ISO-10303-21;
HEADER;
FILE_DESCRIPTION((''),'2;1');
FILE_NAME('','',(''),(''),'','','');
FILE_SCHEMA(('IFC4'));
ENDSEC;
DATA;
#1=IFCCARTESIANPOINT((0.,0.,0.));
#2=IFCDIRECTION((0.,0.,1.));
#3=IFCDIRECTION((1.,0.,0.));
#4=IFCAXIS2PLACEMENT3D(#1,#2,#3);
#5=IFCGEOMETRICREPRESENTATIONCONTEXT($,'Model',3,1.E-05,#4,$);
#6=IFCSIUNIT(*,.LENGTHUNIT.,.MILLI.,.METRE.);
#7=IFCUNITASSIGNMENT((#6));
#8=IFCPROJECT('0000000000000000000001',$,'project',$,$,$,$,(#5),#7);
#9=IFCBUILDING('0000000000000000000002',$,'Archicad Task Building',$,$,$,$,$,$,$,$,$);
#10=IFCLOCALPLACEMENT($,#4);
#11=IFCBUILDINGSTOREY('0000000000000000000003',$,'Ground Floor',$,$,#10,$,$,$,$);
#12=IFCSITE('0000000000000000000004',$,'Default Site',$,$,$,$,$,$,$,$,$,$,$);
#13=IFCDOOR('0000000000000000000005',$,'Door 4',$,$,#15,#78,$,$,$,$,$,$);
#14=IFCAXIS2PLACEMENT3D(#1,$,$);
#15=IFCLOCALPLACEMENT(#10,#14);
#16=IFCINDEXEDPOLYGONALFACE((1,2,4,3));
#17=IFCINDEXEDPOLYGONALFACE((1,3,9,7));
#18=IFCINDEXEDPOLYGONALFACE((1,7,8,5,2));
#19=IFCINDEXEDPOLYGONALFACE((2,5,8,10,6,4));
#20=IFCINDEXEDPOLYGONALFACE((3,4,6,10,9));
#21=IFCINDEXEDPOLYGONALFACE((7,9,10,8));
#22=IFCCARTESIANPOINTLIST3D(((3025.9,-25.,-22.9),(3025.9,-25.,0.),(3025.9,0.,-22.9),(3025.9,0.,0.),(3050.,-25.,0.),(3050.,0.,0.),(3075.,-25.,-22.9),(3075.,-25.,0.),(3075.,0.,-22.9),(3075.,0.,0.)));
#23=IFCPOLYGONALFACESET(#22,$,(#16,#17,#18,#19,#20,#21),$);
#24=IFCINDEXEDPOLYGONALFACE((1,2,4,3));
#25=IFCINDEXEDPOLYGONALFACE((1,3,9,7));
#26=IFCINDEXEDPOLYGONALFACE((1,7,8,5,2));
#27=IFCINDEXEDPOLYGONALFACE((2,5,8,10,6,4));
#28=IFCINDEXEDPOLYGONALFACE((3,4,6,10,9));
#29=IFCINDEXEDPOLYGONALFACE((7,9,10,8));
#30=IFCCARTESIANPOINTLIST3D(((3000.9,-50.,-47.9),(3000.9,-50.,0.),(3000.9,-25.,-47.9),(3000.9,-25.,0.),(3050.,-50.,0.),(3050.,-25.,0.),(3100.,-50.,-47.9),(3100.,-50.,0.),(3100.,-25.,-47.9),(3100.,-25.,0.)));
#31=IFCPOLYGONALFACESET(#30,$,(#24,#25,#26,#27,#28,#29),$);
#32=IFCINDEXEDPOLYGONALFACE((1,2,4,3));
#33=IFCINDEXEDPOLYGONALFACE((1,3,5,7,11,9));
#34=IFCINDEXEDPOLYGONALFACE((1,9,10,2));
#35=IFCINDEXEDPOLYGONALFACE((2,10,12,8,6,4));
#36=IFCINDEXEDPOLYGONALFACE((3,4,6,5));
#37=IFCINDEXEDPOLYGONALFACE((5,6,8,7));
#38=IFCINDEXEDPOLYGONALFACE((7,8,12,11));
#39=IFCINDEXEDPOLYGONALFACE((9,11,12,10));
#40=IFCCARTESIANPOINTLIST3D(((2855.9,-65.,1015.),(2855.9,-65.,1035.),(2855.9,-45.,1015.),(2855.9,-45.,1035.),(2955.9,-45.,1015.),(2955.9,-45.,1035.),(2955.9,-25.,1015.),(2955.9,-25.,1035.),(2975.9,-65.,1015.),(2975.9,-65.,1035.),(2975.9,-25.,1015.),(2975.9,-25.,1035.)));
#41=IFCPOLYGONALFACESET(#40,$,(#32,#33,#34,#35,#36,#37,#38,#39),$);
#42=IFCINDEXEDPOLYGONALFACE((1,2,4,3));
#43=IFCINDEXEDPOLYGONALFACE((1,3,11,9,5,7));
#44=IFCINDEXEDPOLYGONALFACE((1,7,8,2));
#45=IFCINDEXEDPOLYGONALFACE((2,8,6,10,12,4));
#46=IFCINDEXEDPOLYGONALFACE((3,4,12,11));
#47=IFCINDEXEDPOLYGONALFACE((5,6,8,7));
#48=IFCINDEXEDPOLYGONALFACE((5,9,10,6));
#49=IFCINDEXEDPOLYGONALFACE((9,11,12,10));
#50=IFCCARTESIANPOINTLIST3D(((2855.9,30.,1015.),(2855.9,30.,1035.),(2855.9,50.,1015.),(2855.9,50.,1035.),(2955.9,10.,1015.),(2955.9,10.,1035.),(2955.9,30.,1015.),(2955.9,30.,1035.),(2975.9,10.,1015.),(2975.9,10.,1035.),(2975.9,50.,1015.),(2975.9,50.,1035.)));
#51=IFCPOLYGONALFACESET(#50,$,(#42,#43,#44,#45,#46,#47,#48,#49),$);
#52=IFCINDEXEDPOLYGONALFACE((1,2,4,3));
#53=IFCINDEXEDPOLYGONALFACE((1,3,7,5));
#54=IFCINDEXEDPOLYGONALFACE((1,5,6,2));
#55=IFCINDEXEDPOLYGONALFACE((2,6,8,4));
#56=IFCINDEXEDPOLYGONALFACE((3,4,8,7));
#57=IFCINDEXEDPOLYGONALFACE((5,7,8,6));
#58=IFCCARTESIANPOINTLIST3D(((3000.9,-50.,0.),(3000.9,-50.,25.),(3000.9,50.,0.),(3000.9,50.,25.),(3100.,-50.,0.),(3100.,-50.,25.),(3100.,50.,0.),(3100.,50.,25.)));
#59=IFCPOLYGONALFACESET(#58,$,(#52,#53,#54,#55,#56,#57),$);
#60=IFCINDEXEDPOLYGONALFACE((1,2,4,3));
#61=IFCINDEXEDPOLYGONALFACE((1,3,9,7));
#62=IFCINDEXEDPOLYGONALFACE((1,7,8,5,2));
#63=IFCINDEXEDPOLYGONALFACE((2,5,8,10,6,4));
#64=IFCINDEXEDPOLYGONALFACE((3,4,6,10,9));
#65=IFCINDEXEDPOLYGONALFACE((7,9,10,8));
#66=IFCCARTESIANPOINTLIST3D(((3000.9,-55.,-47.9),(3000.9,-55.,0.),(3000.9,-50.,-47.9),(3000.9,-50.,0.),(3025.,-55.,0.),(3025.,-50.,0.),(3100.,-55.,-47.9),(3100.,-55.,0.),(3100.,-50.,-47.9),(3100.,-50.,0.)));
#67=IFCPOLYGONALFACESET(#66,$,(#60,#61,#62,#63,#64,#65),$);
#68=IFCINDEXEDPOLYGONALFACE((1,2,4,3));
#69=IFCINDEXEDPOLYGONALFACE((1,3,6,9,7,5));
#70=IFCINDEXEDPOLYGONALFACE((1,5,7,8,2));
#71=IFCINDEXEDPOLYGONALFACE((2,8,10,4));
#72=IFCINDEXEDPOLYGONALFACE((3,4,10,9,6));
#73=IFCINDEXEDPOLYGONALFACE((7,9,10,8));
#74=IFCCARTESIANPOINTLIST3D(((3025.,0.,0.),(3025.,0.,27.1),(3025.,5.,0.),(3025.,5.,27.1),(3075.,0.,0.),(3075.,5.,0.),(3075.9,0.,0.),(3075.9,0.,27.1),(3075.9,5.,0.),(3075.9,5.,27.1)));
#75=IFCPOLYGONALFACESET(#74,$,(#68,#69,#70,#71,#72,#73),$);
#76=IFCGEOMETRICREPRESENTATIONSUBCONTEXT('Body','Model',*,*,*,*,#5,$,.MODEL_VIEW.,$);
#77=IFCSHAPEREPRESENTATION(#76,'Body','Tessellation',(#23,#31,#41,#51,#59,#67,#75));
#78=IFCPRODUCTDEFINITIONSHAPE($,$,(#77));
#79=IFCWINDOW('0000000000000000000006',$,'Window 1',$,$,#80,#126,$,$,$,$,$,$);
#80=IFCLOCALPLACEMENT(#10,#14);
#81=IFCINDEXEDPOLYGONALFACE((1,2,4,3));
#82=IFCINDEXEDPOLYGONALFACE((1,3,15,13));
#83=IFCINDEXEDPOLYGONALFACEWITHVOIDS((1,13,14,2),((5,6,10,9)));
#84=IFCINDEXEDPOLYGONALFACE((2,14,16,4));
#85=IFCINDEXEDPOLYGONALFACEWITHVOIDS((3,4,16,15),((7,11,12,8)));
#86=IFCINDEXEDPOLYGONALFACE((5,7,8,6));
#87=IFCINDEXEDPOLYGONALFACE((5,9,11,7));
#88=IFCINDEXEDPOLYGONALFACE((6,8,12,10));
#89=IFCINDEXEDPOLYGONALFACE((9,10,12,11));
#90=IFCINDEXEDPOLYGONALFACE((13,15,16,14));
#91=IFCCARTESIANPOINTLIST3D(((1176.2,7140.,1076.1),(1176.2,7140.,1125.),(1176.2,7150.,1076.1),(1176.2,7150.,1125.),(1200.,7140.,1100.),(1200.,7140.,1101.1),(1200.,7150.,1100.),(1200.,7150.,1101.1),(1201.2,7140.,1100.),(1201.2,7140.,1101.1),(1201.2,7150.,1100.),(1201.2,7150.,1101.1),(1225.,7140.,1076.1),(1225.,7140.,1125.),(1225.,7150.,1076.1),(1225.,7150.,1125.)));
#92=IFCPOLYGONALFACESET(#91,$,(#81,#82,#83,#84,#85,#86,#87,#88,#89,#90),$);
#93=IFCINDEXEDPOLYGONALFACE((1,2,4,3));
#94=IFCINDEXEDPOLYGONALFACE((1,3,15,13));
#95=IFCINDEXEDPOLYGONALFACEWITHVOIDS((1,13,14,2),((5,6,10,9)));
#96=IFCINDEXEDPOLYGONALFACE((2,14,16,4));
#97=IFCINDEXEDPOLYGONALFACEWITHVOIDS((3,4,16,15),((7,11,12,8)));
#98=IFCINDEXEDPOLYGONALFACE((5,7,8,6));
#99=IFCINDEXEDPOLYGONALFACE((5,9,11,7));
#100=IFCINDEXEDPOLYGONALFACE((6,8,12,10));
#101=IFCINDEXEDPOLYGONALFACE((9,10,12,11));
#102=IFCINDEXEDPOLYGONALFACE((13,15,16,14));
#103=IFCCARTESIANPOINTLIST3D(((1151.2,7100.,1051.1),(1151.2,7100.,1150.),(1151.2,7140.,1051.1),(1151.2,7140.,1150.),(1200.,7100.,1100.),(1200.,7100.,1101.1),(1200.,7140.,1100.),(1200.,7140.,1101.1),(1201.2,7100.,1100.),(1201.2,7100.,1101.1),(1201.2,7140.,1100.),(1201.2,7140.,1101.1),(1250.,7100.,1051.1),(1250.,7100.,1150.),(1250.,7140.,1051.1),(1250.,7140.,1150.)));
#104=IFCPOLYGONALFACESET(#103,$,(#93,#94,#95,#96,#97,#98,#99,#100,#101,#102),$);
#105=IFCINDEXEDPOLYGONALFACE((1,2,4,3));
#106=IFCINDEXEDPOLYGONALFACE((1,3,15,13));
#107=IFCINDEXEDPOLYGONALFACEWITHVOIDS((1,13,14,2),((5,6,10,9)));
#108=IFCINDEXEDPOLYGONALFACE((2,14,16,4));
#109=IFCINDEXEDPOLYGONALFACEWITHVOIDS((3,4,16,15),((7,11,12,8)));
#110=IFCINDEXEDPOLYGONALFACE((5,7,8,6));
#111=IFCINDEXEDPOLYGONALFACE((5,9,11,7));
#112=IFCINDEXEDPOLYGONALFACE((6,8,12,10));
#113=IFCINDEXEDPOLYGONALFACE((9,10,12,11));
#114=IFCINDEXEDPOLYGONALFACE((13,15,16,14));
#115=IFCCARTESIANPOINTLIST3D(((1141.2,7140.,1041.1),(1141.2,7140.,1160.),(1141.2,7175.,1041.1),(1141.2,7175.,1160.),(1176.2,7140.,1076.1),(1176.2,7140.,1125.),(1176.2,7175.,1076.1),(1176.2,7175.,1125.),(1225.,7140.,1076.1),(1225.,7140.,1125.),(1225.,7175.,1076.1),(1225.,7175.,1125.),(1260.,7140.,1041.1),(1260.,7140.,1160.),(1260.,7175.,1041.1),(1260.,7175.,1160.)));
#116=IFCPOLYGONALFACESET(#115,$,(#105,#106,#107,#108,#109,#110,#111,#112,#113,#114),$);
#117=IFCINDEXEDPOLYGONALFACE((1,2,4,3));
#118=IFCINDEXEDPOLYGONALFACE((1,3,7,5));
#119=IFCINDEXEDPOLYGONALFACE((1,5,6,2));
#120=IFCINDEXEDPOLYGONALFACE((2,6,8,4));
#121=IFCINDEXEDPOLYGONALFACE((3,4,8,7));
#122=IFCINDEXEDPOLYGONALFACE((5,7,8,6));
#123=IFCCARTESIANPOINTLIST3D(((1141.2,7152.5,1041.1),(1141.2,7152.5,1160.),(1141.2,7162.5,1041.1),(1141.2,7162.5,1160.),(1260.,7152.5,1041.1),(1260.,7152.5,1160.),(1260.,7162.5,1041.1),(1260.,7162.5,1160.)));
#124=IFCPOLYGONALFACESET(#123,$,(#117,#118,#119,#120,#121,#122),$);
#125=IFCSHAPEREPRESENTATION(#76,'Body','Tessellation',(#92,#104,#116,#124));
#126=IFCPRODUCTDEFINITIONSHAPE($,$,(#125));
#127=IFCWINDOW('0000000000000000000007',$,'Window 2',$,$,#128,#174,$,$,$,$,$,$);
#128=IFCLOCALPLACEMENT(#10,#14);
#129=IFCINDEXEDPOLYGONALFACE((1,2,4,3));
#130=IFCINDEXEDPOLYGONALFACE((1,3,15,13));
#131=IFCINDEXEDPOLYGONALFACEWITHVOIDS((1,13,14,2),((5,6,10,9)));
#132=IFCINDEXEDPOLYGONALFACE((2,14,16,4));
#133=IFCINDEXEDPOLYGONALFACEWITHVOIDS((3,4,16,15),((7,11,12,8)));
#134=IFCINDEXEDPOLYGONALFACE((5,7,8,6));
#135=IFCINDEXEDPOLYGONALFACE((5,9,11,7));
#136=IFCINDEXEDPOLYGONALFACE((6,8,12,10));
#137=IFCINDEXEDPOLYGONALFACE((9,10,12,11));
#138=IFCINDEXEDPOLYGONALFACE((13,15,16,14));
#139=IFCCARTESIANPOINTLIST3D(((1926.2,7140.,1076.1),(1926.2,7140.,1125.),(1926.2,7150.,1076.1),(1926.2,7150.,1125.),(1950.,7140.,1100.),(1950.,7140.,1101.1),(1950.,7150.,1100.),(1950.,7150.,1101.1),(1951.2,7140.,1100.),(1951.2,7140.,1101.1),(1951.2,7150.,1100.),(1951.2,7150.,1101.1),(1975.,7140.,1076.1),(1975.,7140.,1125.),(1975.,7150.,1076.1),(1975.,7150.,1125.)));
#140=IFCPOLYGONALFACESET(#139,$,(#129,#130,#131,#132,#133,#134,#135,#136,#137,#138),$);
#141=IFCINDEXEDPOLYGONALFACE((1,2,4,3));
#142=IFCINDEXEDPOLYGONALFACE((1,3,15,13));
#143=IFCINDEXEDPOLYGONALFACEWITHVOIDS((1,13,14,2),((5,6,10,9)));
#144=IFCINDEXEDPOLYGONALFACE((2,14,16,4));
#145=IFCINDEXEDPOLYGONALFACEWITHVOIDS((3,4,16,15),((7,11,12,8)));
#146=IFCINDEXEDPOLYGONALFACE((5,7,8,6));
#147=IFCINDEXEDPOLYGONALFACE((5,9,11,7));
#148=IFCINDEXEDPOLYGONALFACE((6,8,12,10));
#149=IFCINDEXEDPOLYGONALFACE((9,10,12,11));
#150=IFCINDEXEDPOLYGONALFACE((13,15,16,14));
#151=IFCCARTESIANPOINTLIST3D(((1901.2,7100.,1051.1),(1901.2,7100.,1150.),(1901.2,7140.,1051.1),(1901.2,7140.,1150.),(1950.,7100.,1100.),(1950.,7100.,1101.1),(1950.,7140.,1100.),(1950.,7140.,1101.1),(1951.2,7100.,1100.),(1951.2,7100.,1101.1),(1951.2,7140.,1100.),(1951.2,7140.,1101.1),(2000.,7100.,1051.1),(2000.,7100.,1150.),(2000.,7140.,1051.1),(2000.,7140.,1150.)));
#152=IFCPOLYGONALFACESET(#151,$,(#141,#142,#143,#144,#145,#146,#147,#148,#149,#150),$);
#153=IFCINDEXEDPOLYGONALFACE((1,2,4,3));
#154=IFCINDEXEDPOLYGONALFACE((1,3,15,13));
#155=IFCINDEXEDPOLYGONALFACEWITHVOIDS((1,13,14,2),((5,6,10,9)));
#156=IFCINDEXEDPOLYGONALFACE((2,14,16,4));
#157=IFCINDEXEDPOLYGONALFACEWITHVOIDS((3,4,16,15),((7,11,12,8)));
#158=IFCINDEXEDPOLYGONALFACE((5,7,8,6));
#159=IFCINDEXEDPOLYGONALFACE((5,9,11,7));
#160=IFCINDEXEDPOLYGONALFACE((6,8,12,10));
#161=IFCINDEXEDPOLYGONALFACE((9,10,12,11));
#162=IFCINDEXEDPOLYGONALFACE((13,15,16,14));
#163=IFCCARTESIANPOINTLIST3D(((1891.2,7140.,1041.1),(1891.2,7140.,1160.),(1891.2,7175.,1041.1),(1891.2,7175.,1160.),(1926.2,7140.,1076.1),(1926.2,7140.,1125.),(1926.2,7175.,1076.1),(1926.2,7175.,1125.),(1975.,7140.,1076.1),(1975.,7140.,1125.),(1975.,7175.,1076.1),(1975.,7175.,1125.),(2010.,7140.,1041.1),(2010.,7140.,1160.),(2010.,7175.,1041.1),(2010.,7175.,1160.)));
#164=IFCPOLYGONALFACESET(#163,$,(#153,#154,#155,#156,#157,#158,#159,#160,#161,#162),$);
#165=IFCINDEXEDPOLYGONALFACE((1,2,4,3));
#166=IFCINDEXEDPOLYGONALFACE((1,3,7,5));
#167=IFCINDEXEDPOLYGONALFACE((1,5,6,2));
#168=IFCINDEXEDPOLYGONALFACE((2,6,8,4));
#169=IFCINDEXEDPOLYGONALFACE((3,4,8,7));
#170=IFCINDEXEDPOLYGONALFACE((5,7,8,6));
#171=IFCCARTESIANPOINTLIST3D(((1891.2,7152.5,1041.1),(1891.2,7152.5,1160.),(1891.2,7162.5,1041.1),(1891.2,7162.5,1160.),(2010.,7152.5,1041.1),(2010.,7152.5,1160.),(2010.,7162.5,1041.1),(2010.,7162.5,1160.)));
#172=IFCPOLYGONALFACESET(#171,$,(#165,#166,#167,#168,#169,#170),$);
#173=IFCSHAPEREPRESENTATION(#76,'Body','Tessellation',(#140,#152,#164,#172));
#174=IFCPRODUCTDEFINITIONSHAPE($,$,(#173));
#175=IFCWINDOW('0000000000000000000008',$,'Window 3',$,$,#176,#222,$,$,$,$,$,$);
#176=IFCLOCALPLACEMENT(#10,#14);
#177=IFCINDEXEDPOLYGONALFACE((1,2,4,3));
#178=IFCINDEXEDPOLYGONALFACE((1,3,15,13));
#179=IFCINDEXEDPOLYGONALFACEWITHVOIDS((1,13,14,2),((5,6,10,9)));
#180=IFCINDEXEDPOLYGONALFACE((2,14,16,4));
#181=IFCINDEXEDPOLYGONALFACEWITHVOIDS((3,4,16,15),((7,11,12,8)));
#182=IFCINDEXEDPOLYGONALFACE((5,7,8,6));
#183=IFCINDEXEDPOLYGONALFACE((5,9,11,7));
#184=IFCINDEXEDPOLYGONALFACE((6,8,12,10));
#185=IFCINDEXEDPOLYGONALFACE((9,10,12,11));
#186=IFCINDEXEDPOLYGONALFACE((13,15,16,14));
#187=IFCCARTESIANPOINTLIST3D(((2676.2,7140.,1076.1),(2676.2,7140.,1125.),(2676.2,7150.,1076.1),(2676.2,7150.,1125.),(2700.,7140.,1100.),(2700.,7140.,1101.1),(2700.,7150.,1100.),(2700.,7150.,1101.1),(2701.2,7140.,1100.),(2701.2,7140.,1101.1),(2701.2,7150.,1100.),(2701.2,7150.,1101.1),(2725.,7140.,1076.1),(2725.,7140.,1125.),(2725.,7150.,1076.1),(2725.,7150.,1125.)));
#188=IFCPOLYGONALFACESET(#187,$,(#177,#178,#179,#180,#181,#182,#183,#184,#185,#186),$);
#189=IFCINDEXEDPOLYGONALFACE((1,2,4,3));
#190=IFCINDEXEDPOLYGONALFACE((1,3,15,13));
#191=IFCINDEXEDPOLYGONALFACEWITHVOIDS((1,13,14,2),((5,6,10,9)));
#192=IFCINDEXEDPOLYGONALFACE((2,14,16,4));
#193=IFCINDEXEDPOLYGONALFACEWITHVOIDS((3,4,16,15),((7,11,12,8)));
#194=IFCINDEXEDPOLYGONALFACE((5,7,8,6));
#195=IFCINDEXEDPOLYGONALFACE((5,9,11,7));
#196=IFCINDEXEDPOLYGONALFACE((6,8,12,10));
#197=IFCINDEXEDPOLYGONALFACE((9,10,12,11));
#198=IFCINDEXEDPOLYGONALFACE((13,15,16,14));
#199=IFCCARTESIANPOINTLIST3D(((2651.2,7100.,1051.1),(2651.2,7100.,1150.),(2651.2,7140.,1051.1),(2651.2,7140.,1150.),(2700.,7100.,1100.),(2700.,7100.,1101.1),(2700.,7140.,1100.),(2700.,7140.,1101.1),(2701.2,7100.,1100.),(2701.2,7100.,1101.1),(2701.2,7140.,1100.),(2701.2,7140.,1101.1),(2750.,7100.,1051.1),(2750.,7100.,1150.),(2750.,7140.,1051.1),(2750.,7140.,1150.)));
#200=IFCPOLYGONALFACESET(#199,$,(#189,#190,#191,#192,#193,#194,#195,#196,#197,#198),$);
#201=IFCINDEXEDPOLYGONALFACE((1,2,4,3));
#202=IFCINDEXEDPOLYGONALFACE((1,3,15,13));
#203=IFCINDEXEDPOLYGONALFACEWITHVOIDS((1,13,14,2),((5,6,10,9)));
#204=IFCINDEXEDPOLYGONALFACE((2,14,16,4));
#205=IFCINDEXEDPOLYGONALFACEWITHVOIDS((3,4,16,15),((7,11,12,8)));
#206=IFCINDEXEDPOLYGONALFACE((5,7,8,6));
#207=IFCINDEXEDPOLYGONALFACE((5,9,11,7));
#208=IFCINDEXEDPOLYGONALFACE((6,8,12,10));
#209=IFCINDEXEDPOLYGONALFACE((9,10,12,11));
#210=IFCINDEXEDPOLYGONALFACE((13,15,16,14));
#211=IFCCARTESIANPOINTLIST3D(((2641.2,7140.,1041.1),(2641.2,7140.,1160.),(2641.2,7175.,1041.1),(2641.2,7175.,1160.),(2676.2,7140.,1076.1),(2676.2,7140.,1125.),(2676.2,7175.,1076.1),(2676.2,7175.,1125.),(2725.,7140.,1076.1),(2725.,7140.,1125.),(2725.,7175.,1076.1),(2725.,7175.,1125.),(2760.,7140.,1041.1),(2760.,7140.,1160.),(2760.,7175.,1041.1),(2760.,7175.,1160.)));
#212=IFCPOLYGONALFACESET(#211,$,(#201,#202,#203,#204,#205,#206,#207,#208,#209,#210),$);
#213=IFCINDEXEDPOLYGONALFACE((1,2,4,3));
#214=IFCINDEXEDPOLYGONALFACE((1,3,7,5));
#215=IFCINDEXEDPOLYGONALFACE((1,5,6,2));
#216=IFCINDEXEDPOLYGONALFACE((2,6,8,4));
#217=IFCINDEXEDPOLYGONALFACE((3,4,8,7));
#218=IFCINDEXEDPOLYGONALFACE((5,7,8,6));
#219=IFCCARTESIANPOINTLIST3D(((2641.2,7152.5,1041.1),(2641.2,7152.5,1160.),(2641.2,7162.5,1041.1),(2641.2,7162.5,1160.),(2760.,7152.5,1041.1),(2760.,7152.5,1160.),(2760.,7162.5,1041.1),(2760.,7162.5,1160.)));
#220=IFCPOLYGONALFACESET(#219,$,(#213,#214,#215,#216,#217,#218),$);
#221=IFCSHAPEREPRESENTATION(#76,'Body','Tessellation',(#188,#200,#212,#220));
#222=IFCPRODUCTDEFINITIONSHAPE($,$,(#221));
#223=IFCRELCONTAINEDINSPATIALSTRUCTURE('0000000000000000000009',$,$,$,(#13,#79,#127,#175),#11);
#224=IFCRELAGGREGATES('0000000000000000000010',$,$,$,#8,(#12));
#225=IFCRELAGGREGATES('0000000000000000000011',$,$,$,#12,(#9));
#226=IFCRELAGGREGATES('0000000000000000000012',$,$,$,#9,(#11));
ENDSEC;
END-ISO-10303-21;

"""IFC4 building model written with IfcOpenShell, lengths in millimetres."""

from ifc_helpers import new_model, si_unit, frame, origin_with_axes, place, context, subcontext, project, spatial, line, indexed_curve, outline, extrude, element, save


model = new_model("IFC4")

# Units and contexts
model_context = context("Model", 3, precision=1e-05, world=origin_with_axes())
body_context = subcontext(model_context, "Body", "Model", "MODEL_VIEW")
ifc_project = project(units=[si_unit("LENGTHUNIT", "METRE", prefix="MILLI")], contexts=[model_context])

# Site, building, storey
site = spatial("IfcSite", under=ifc_project, Name="Default Site")
building = spatial("IfcBuilding", under=site, Name="Archicad Task Building")
storey_placement = place(None, origin_with_axes())
storey = spatial("IfcBuildingStorey", under=building, at=storey_placement, Name="Ground Floor")

# Door
door_1_placement = place(storey_placement, frame((3050.0, -50.0, 0.0), z_axis=(0.0, 0.0, 1.0), x_axis=(1.0, 0.0, 0.0)))
element("IfcDoor", 1, at=door_1_placement, inside=storey, Name="Door 4", context=body_context, shape_type="SweptSolid", body=[
    extrude(outline(indexed_curve([(0.0, 0.0), (0.0, 2.1), (0.9, 2.1), (0.9, 0.0), (-24.1, 0.0), (-24.1, -22.9), (25.0, -22.9), (25.0, 0.0)], segments=[line(1, 2, 3, 4, 5, 6, 7, 8, 1)])), frame((0.0, 25.0, 0.0), z_axis=(0.0, -1.0, 0.0), x_axis=(1.0, 0.0, 0.0)), (0.0, 0.0, -1.0), 25.0),
    extrude(outline(indexed_curve([(0.0, 0.0), (0.0, 2.1), (0.9, 2.1), (0.9, 0.0), (-49.1, 0.0), (-49.1, -47.9), (50.0, -47.9), (50.0, 0.0)], segments=[line(1, 2, 3, 4, 5, 6, 7, 8, 1)])), frame((0.0, 0.0, 0.0), z_axis=(0.0, -1.0, 0.0), x_axis=(1.0, 0.0, 0.0)), (0.0, 0.0, -1.0), 25.0),
    extrude(outline(indexed_curve([(0.0, 0.0), (-49.1, 0.0), (-49.1, 35.0), (0.0, 35.0)], segments=[line(1, 2, 3, 4, 1)])), frame((25.0, 25.0, 25.0), z_axis=(0.0, 0.0, 1.0), x_axis=(1.0, 0.0, 0.0)), (0.0, 0.0, 1.0), -47.9),
    extrude(outline(indexed_curve([(0.0, 0.0), (0.0, -40.0), (-120.0, -40.0), (-120.0, -20.0), (-20.0, -20.0), (-20.0, 0.0)], segments=[line(1, 2, 3, 4, 5, 6, 1)])), frame((-74.1, 25.0, 1015.0), z_axis=(0.0, 0.0, 1.0), x_axis=(1.0, 0.0, 0.0)), (0.0, 0.0, 1.0), 20.0),
    extrude(outline(indexed_curve([(0.0, 0.0), (0.0, 40.0), (-120.0, 40.0), (-120.0, 20.0), (-20.0, 20.0), (-20.0, 0.0)], segments=[line(1, 2, 3, 4, 5, 6, 1)])), frame((-74.1, 60.0, 1015.0), z_axis=(0.0, 0.0, 1.0), x_axis=(1.0, 0.0, 0.0)), (0.0, 0.0, 1.0), 20.0),
    extrude(outline(indexed_curve([(0.0, 0.0), (-99.1, 0.0), (-99.1, 100.0), (0.0, 100.0)], segments=[line(1, 2, 3, 4, 1)])), frame((50.0, 0.0, 0.0), z_axis=(0.0, 0.0, 1.0), x_axis=(1.0, 0.0, 0.0)), (0.0, 0.0, 1.0), 25.0),
    extrude(outline(indexed_curve([(0.0, 0.0), (0.0, 27.1), (50.9, 27.1), (50.9, 0.0), (-24.1, 0.0), (-24.1, -47.9), (75.0, -47.9), (75.0, 0.0)], segments=[line(1, 2, 3, 4, 5, 6, 7, 8, 1)])), frame((-25.0, -5.0, 0.0), z_axis=(0.0, -1.0, 0.0), x_axis=(1.0, 0.0, 0.0)), (0.0, 0.0, -1.0), 5.0),
    extrude(outline(indexed_curve([(0.0, 0.0), (0.0, 27.1), (50.9, 27.1), (50.9, 0.0), (0.9, 0.0), (0.9, -22.9), (50.0, -22.9), (50.0, 0.0)], segments=[line(1, 2, 3, 4, 5, 6, 7, 8, 1)])), frame((-25.0, 50.0, 0.0), z_axis=(0.0, -1.0, 0.0), x_axis=(1.0, 0.0, 0.0)), (0.0, 0.0, -1.0), 5.0),
])

# Windows
for number, where, z_axis, x_axis, name in (
    (2, (1200.0, 7050.0, 1100.0), (0.0, 0.0, 1.0), (1.0, 0.0, 0.0), "Window 1"),
    (3, (1950.0, 7050.0, 1100.0), (0.0, 0.0, 1.0), (1.0, 0.0, 0.0), "Window 2"),
    (4, (2700.0, 7050.0, 1100.0), (0.0, 0.0, 1.0), (1.0, 0.0, 0.0), "Window 3"),
):
    element("IfcWindow", number, at=place(storey_placement, frame(where, z_axis=z_axis, x_axis=x_axis)), inside=storey, Name=name, context=body_context, shape_type="SweptSolid", body=[
        extrude(outline(indexed_curve([(0.0, 0.0), (1.2, 0.0), (1.2, 1.1), (0.0, 1.1)], segments=[line(1, 2, 3, 4, 1)]), holes=[indexed_curve([(25.0, 25.0), (-23.8, 25.0), (-23.8, -23.9), (25.0, -23.9)], segments=[line(1, 2, 3, 4, 1)])]), frame((0.0, 90.0, 0.0), z_axis=(0.0, -1.0, 0.0), x_axis=(1.0, 0.0, 0.0)), (0.0, 0.0, -1.0), 10.0),
        extrude(outline(indexed_curve([(0.0, 0.0), (1.2, 0.0), (1.2, 1.1), (0.0, 1.1)], segments=[line(1, 2, 3, 4, 1)]), holes=[indexed_curve([(50.0, 50.0), (-48.8, 50.0), (-48.8, -48.9), (50.0, -48.9)], segments=[line(1, 2, 3, 4, 1)])]), frame((0.0, 50.0, 0.0), z_axis=(0.0, -1.0, 0.0), x_axis=(1.0, 0.0, 0.0)), (0.0, 0.0, -1.0), 40.0),
        extrude(outline(indexed_curve([(0.0, 0.0), (-48.8, 0.0), (-48.8, -48.9), (0.0, -48.9)], segments=[line(1, 2, 3, 4, 1)]), holes=[indexed_curve([(35.0, 35.0), (-83.8, 35.0), (-83.8, -83.9), (35.0, -83.9)], segments=[line(1, 2, 3, 4, 1)])]), frame((25.0, 90.0, 25.0), z_axis=(0.0, -1.0, 0.0), x_axis=(1.0, 0.0, 0.0)), (0.0, 0.0, -1.0), 35.0),
        extrude(outline(indexed_curve([(35.0, 35.0), (-83.8, 35.0), (-83.8, -83.9), (35.0, -83.9)], segments=[line(1, 2, 3, 4, 1)])), frame((25.0, 102.5, 25.0), z_axis=(0.0, -1.0, 0.0), x_axis=(1.0, 0.0, 0.0)), (0.0, 0.0, -1.0), 10.0),
    ])

save(model, "model.ifc")
